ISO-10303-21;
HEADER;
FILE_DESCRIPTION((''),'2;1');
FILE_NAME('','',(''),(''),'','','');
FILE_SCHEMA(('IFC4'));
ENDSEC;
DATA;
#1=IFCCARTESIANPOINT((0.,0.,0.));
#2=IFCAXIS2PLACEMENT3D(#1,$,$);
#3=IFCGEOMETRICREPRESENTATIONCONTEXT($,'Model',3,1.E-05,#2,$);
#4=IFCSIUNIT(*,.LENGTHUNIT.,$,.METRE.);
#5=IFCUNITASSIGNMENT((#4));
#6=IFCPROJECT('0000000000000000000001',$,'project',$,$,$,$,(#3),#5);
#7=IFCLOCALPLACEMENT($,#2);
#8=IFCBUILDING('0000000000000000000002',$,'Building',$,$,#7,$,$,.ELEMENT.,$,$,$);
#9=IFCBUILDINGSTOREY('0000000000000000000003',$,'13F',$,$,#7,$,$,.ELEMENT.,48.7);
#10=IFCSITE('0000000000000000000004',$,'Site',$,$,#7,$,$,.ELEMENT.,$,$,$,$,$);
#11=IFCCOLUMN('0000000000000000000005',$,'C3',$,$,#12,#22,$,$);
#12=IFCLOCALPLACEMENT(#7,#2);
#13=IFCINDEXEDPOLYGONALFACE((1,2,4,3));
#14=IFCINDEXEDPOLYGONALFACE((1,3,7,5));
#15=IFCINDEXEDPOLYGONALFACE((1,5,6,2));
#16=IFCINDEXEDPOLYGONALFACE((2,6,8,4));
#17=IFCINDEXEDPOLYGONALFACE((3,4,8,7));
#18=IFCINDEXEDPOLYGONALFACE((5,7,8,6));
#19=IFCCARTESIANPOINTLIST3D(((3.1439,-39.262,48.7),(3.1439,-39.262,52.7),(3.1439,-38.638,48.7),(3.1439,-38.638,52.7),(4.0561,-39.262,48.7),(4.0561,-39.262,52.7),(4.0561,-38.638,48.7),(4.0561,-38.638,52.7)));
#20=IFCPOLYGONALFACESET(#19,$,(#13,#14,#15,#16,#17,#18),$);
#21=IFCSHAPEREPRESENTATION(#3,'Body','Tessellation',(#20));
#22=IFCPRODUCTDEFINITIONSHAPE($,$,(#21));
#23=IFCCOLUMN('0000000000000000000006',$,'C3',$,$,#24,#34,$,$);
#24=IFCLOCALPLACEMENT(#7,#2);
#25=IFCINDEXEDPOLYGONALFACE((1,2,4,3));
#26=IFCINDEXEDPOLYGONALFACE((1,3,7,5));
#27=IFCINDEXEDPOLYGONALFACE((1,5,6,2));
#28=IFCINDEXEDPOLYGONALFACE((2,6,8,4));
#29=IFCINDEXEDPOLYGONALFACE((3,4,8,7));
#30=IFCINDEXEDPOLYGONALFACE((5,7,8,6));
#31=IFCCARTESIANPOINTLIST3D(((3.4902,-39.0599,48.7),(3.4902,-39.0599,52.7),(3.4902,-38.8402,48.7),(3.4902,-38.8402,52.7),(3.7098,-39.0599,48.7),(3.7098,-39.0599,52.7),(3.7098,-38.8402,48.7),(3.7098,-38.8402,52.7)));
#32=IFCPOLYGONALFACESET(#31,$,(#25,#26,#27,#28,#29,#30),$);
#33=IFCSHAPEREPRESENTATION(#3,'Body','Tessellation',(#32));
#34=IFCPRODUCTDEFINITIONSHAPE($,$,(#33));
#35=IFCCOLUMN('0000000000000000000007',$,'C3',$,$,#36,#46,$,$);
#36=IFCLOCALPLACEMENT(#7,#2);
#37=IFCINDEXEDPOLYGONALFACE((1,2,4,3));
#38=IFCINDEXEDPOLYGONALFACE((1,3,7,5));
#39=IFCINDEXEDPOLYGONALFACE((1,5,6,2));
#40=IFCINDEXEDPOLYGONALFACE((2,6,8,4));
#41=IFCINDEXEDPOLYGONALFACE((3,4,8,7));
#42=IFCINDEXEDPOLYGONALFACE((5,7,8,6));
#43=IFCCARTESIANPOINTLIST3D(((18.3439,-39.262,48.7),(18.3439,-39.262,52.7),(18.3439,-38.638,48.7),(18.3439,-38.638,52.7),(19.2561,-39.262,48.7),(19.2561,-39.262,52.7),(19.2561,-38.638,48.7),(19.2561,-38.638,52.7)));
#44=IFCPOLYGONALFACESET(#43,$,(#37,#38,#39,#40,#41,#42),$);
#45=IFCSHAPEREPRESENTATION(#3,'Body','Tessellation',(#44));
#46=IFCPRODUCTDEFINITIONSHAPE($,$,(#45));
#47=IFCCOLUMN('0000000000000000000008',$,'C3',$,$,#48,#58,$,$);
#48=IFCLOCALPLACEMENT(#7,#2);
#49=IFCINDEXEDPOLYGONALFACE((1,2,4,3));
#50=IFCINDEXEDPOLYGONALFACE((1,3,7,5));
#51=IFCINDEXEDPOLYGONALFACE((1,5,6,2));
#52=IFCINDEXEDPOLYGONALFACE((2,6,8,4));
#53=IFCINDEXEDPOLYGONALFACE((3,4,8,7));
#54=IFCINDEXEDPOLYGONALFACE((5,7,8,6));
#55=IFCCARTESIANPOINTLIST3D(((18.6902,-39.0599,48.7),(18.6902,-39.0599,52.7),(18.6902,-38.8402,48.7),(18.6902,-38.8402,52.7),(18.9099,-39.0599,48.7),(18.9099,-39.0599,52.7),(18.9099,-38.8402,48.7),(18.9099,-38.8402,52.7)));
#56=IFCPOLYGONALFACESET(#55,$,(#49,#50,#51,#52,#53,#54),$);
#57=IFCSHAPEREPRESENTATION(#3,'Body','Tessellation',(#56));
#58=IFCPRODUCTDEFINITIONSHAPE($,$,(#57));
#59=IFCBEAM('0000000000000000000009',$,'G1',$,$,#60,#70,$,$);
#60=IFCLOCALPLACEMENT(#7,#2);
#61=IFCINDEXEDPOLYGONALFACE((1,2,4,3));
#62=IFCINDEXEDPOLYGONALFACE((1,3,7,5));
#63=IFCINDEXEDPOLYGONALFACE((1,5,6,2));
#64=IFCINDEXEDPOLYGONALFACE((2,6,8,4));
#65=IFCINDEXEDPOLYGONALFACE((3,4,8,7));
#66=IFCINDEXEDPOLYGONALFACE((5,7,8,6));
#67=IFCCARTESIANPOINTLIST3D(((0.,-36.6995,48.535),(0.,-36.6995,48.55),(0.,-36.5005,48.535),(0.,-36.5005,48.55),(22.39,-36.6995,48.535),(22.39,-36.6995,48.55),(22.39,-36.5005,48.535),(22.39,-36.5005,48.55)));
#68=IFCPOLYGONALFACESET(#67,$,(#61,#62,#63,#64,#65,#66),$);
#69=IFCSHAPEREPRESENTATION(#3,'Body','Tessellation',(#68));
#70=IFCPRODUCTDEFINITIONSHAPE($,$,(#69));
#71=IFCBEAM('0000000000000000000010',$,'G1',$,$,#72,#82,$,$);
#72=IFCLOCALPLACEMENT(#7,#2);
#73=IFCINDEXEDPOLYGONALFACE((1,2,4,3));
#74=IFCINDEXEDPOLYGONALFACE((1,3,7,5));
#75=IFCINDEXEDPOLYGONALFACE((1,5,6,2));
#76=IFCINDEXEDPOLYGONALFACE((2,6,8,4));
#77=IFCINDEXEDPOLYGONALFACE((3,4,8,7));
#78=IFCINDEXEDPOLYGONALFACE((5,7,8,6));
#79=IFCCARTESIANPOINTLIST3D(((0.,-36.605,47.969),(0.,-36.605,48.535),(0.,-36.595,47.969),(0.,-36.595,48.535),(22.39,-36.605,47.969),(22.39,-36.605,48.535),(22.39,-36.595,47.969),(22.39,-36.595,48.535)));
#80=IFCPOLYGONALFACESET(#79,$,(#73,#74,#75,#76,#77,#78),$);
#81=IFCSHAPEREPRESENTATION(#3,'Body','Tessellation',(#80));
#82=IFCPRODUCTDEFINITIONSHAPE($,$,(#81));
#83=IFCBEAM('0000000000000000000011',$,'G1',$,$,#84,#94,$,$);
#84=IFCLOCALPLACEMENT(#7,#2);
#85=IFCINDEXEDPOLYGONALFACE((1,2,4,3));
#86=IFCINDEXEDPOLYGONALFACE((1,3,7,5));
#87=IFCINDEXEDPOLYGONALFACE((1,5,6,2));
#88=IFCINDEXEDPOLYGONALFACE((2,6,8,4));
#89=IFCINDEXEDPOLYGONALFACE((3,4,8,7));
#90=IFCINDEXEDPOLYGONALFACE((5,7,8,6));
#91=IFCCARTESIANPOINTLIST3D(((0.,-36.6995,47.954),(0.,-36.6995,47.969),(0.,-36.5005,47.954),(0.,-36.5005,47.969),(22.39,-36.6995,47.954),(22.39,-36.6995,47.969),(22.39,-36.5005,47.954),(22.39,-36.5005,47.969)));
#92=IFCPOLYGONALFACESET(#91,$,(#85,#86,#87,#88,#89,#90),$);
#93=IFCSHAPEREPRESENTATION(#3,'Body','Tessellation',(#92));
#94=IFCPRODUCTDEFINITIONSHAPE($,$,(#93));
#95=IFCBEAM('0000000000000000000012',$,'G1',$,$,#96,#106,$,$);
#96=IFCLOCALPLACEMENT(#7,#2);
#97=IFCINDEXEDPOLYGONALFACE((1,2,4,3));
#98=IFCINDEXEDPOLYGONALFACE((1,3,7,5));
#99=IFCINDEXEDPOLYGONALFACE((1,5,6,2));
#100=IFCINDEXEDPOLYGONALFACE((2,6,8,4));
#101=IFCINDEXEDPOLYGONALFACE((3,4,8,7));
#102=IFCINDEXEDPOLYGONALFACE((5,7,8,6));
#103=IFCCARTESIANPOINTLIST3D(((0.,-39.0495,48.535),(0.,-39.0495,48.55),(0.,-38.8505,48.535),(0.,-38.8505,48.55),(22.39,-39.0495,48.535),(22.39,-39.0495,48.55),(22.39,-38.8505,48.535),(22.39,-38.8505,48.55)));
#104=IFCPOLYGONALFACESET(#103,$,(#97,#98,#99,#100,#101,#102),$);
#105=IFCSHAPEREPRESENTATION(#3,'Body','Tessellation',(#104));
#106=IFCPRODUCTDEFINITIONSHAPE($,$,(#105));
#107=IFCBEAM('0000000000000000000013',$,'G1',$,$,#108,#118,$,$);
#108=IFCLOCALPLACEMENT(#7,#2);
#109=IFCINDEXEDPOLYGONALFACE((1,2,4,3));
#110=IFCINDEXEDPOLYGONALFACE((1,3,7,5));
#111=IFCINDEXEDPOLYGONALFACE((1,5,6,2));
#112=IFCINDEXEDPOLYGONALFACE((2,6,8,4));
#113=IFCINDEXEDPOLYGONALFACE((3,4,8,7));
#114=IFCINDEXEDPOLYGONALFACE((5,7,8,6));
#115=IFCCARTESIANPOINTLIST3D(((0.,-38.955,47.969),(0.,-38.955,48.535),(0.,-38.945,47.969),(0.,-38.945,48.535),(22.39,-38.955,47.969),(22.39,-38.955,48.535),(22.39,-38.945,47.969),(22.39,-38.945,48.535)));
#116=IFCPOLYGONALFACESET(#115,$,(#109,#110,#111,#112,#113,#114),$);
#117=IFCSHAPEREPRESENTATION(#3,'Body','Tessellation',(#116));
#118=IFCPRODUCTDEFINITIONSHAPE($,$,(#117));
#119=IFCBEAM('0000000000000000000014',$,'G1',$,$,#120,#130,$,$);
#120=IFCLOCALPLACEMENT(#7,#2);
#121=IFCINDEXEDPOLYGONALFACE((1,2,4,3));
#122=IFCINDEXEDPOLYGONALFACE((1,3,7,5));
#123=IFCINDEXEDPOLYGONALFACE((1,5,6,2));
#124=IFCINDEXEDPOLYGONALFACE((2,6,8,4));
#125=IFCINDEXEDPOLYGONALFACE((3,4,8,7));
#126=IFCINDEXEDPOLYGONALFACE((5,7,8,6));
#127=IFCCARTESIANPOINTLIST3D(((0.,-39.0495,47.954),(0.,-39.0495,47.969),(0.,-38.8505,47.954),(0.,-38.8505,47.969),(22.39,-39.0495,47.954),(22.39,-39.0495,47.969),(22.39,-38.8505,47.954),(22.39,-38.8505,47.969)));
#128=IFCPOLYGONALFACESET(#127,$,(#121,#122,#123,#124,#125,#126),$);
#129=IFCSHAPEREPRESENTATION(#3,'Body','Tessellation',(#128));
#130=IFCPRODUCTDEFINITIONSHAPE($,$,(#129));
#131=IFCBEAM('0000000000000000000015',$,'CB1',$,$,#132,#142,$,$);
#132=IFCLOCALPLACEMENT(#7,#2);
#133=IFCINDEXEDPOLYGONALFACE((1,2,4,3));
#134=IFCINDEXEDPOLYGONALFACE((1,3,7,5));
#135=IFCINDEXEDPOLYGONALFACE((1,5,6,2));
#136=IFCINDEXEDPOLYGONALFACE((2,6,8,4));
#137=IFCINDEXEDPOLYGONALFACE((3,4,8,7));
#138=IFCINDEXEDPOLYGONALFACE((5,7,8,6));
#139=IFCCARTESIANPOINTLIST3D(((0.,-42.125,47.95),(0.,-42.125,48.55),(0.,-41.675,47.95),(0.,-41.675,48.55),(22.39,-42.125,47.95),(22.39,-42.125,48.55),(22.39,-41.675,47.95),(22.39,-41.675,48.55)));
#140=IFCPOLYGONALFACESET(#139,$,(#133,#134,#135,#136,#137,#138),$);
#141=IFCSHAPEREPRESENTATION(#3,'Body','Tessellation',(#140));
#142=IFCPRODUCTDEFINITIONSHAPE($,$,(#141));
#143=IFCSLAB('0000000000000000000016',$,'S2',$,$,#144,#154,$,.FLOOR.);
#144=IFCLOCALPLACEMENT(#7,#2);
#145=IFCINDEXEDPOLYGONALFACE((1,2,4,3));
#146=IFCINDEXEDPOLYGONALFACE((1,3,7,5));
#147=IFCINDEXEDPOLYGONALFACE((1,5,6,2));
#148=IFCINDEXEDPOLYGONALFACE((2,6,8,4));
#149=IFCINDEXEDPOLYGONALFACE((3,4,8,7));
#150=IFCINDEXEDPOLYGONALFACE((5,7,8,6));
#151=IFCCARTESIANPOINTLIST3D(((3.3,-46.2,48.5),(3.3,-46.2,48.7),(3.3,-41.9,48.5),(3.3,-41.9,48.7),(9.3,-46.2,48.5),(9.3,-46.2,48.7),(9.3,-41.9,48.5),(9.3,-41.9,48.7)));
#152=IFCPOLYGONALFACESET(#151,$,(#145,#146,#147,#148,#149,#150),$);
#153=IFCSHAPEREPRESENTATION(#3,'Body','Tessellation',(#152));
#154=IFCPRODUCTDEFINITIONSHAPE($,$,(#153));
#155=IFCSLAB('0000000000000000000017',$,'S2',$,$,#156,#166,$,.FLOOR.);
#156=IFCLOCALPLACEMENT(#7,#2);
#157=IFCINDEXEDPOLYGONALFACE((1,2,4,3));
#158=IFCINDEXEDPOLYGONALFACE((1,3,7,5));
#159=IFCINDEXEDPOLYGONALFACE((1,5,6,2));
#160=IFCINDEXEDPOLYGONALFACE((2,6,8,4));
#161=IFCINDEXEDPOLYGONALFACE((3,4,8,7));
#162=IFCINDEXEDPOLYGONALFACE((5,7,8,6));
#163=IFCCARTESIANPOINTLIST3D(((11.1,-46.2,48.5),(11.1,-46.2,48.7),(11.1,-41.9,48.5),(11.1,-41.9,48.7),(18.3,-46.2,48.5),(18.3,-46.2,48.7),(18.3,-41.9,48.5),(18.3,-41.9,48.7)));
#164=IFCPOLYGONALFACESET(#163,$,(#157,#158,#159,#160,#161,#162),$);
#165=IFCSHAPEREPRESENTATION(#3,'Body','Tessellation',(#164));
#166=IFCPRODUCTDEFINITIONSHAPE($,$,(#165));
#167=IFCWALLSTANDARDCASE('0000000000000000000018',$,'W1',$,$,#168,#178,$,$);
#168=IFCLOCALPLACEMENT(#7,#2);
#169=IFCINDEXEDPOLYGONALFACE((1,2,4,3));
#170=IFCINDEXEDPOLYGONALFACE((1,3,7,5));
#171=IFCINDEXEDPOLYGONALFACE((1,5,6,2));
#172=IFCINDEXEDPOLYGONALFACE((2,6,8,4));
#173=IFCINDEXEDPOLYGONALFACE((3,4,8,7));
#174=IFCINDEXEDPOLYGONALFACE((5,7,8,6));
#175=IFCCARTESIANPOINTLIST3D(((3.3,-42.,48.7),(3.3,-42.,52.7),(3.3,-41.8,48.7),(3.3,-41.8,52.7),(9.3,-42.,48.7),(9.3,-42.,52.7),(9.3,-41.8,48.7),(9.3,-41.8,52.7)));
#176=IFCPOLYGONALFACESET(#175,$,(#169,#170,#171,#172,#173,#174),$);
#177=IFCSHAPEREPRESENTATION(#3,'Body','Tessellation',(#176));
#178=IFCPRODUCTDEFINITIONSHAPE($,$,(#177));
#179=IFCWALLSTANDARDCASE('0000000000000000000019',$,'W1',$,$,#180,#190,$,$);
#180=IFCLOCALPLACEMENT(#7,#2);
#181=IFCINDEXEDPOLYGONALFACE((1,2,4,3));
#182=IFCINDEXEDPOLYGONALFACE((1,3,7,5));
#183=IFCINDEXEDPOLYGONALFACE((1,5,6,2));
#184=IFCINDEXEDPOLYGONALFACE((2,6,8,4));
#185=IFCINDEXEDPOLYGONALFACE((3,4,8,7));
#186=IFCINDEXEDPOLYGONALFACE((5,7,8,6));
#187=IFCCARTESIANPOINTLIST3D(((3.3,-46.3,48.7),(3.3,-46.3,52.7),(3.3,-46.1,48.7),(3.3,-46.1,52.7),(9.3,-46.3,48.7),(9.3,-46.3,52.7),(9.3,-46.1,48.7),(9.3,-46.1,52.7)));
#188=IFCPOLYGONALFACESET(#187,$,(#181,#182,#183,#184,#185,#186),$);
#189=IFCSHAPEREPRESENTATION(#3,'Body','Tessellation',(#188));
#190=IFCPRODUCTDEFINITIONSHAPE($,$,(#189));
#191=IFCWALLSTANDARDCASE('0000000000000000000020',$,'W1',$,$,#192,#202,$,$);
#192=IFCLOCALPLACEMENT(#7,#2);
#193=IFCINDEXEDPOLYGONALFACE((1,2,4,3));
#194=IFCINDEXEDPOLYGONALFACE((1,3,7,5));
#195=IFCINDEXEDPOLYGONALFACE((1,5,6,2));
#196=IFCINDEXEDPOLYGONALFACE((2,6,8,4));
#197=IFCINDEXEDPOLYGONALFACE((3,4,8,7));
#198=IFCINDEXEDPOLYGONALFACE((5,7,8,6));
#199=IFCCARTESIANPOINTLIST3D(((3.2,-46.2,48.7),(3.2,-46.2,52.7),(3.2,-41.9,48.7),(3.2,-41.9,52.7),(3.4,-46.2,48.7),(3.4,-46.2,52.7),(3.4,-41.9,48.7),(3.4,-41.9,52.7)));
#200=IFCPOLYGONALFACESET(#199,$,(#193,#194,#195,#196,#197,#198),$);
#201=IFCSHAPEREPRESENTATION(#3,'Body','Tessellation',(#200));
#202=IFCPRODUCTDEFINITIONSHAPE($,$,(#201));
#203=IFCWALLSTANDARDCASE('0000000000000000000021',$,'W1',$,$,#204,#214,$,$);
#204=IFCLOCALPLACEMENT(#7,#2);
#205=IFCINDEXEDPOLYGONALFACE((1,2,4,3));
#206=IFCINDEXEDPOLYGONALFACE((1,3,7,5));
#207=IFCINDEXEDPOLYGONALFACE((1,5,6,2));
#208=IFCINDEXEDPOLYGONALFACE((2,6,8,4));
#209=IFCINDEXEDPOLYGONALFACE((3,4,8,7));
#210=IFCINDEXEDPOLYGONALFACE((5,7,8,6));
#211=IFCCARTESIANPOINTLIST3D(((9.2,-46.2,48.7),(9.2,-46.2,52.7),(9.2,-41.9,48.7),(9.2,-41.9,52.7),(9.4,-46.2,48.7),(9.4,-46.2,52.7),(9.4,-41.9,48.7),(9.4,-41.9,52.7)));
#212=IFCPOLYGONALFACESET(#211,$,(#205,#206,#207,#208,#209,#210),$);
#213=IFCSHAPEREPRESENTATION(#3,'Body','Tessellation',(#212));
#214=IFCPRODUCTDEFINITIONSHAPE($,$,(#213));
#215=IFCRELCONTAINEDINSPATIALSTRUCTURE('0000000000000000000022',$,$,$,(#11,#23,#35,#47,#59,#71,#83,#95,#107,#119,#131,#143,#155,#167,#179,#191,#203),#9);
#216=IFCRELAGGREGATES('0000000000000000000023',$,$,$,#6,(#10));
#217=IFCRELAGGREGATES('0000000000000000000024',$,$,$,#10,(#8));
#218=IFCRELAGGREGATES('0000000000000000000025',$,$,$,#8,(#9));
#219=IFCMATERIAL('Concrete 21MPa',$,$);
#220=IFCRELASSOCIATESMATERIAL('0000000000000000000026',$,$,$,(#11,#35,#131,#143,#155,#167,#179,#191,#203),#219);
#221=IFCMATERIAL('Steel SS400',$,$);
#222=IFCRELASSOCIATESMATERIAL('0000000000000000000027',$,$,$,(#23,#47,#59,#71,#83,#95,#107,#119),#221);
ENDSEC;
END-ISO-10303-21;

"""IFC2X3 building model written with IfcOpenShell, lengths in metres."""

from ifc_helpers import new_model, si_unit, frame, origin, origin_2d, place, context, project, spatial, rectangle, extrude, material, element, save


model = new_model("IFC2X3")

# Units and contexts
model_context = context("Model", 3, precision=1e-05, world=origin())
ifc_project = project(units=[si_unit("LENGTHUNIT", "METRE")], contexts=[model_context])

# Site, building, storey
placement = place(None, origin())
site = spatial("IfcSite", under=ifc_project, at=placement, Name="Site", CompositionType="ELEMENT")
building = spatial("IfcBuilding", under=site, at=placement, Name="Building", CompositionType="ELEMENT")
storey = spatial("IfcBuildingStorey", under=building, at=placement, Name="13F", CompositionType="ELEMENT", Elevation=48.7)

# Columns
ifc_material_1 = material(Name="Concrete 21MPa")
column_1_placement = place(None, frame((3.6, -38.95, 48.7)))
element("IfcColumn", 1, at=column_1_placement, inside=storey, material=ifc_material_1, Name="C3", context=model_context, shape_type="SweptSolid", body=[
    extrude(rectangle(XDim=0.9121, YDim=0.6241, at=origin_2d()), origin(), (0.0, 0.0, 1.0), 4.0),
])
ifc_material_2 = material(Name="Steel SS400")
column_2_placement = place(None, frame((3.6, -38.95, 48.7)))
element("IfcColumn", 2, at=column_2_placement, inside=storey, material=ifc_material_2, Name="C3", context=model_context, shape_type="SweptSolid", body=[
    extrude(rectangle(XDim=0.2197, YDim=0.2197, at=origin_2d()), origin(), (0.0, 0.0, 1.0), 4.0),
])
column_3_placement = place(None, frame((18.8, -38.95, 48.7)))
element("IfcColumn", 3, at=column_3_placement, inside=storey, material=ifc_material_1, Name="C3", context=model_context, shape_type="SweptSolid", body=[
    extrude(rectangle(XDim=0.9121, YDim=0.6241, at=origin_2d()), origin(), (0.0, 0.0, 1.0), 4.0),
])
column_4_placement = place(None, frame((18.8, -38.95, 48.7)))
element("IfcColumn", 4, at=column_4_placement, inside=storey, material=ifc_material_2, Name="C3", context=model_context, shape_type="SweptSolid", body=[
    extrude(rectangle(XDim=0.2197, YDim=0.2197, at=origin_2d()), origin(), (0.0, 0.0, 1.0), 4.0),
])

# Beams
beam_1_placement = place(None, frame((11.195, -36.6, 48.535)))
element("IfcBeam", 5, at=beam_1_placement, inside=storey, material=ifc_material_2, Name="G1", context=model_context, shape_type="SweptSolid", body=[
    extrude(rectangle(XDim=22.39, YDim=0.199, at=origin_2d()), origin(), (0.0, 0.0, 1.0), 0.015),
])
beam_2_placement = place(None, frame((11.195, -36.6, 47.969)))
element("IfcBeam", 6, at=beam_2_placement, inside=storey, material=ifc_material_2, Name="G1", context=model_context, shape_type="SweptSolid", body=[
    extrude(rectangle(XDim=22.39, YDim=0.01, at=origin_2d()), origin(), (0.0, 0.0, 1.0), 0.566),
])
for number, where, name in (
    (7, (11.195, -36.6, 47.954), "G1"),
    (8, (11.195, -38.95, 48.535), "G1"),
):
    element("IfcBeam", number, at=place(None, frame(where)), inside=storey, material=ifc_material_2, Name=name, context=model_context, shape_type="SweptSolid", body=[
        extrude(rectangle(XDim=22.39, YDim=0.199, at=origin_2d()), origin(), (0.0, 0.0, 1.0), 0.015),
    ])
beam_3_placement = place(None, frame((11.195, -38.95, 47.969)))
element("IfcBeam", 9, at=beam_3_placement, inside=storey, material=ifc_material_2, Name="G1", context=model_context, shape_type="SweptSolid", body=[
    extrude(rectangle(XDim=22.39, YDim=0.01, at=origin_2d()), origin(), (0.0, 0.0, 1.0), 0.566),
])
beam_4_placement = place(None, frame((11.195, -38.95, 47.954)))
element("IfcBeam", 10, at=beam_4_placement, inside=storey, material=ifc_material_2, Name="G1", context=model_context, shape_type="SweptSolid", body=[
    extrude(rectangle(XDim=22.39, YDim=0.199, at=origin_2d()), origin(), (0.0, 0.0, 1.0), 0.015),
])
beam_5_placement = place(None, frame((11.195, -41.9, 47.95)))
element("IfcBeam", 11, at=beam_5_placement, inside=storey, material=ifc_material_1, Name="CB1", context=model_context, shape_type="SweptSolid", body=[
    extrude(rectangle(XDim=22.39, YDim=0.45, at=origin_2d()), origin(), (0.0, 0.0, 1.0), 0.6),
])

# Slabs
slab_1_placement = place(None, frame((6.3, -44.05, 48.5)))
element("IfcSlab", 12, at=slab_1_placement, inside=storey, material=ifc_material_1, Name="S2", PredefinedType="FLOOR", context=model_context, shape_type="SweptSolid", body=[
    extrude(rectangle(XDim=6.0, YDim=4.3, at=origin_2d()), origin(), (0.0, 0.0, 1.0), 0.2),
])
slab_2_placement = place(None, frame((14.7, -44.05, 48.5)))
element("IfcSlab", 13, at=slab_2_placement, inside=storey, material=ifc_material_1, Name="S2", PredefinedType="FLOOR", context=model_context, shape_type="SweptSolid", body=[
    extrude(rectangle(XDim=7.2, YDim=4.3, at=origin_2d()), origin(), (0.0, 0.0, 1.0), 0.2),
])

# Walls
for number, where, name in (
    (14, (6.3, -41.9, 48.7), "W1"),
    (15, (6.3, -46.2, 48.7), "W1"),
):
    element("IfcWallStandardCase", number, at=place(None, frame(where)), inside=storey, material=ifc_material_1, Name=name, context=model_context, shape_type="SweptSolid", body=[
        extrude(rectangle(XDim=6.0, YDim=0.2, at=origin_2d()), origin(), (0.0, 0.0, 1.0), 4.0),
    ])
for number, where, name in (
    (16, (3.3, -44.05, 48.7), "W1"),
    (17, (9.3, -44.05, 48.7), "W1"),
):
    element("IfcWallStandardCase", number, at=place(None, frame(where)), inside=storey, material=ifc_material_1, Name=name, context=model_context, shape_type="SweptSolid", body=[
        extrude(rectangle(XDim=0.2, YDim=4.3, at=origin_2d()), origin(), (0.0, 0.0, 1.0), 4.0),
    ])

save(model, "model.ifc")
